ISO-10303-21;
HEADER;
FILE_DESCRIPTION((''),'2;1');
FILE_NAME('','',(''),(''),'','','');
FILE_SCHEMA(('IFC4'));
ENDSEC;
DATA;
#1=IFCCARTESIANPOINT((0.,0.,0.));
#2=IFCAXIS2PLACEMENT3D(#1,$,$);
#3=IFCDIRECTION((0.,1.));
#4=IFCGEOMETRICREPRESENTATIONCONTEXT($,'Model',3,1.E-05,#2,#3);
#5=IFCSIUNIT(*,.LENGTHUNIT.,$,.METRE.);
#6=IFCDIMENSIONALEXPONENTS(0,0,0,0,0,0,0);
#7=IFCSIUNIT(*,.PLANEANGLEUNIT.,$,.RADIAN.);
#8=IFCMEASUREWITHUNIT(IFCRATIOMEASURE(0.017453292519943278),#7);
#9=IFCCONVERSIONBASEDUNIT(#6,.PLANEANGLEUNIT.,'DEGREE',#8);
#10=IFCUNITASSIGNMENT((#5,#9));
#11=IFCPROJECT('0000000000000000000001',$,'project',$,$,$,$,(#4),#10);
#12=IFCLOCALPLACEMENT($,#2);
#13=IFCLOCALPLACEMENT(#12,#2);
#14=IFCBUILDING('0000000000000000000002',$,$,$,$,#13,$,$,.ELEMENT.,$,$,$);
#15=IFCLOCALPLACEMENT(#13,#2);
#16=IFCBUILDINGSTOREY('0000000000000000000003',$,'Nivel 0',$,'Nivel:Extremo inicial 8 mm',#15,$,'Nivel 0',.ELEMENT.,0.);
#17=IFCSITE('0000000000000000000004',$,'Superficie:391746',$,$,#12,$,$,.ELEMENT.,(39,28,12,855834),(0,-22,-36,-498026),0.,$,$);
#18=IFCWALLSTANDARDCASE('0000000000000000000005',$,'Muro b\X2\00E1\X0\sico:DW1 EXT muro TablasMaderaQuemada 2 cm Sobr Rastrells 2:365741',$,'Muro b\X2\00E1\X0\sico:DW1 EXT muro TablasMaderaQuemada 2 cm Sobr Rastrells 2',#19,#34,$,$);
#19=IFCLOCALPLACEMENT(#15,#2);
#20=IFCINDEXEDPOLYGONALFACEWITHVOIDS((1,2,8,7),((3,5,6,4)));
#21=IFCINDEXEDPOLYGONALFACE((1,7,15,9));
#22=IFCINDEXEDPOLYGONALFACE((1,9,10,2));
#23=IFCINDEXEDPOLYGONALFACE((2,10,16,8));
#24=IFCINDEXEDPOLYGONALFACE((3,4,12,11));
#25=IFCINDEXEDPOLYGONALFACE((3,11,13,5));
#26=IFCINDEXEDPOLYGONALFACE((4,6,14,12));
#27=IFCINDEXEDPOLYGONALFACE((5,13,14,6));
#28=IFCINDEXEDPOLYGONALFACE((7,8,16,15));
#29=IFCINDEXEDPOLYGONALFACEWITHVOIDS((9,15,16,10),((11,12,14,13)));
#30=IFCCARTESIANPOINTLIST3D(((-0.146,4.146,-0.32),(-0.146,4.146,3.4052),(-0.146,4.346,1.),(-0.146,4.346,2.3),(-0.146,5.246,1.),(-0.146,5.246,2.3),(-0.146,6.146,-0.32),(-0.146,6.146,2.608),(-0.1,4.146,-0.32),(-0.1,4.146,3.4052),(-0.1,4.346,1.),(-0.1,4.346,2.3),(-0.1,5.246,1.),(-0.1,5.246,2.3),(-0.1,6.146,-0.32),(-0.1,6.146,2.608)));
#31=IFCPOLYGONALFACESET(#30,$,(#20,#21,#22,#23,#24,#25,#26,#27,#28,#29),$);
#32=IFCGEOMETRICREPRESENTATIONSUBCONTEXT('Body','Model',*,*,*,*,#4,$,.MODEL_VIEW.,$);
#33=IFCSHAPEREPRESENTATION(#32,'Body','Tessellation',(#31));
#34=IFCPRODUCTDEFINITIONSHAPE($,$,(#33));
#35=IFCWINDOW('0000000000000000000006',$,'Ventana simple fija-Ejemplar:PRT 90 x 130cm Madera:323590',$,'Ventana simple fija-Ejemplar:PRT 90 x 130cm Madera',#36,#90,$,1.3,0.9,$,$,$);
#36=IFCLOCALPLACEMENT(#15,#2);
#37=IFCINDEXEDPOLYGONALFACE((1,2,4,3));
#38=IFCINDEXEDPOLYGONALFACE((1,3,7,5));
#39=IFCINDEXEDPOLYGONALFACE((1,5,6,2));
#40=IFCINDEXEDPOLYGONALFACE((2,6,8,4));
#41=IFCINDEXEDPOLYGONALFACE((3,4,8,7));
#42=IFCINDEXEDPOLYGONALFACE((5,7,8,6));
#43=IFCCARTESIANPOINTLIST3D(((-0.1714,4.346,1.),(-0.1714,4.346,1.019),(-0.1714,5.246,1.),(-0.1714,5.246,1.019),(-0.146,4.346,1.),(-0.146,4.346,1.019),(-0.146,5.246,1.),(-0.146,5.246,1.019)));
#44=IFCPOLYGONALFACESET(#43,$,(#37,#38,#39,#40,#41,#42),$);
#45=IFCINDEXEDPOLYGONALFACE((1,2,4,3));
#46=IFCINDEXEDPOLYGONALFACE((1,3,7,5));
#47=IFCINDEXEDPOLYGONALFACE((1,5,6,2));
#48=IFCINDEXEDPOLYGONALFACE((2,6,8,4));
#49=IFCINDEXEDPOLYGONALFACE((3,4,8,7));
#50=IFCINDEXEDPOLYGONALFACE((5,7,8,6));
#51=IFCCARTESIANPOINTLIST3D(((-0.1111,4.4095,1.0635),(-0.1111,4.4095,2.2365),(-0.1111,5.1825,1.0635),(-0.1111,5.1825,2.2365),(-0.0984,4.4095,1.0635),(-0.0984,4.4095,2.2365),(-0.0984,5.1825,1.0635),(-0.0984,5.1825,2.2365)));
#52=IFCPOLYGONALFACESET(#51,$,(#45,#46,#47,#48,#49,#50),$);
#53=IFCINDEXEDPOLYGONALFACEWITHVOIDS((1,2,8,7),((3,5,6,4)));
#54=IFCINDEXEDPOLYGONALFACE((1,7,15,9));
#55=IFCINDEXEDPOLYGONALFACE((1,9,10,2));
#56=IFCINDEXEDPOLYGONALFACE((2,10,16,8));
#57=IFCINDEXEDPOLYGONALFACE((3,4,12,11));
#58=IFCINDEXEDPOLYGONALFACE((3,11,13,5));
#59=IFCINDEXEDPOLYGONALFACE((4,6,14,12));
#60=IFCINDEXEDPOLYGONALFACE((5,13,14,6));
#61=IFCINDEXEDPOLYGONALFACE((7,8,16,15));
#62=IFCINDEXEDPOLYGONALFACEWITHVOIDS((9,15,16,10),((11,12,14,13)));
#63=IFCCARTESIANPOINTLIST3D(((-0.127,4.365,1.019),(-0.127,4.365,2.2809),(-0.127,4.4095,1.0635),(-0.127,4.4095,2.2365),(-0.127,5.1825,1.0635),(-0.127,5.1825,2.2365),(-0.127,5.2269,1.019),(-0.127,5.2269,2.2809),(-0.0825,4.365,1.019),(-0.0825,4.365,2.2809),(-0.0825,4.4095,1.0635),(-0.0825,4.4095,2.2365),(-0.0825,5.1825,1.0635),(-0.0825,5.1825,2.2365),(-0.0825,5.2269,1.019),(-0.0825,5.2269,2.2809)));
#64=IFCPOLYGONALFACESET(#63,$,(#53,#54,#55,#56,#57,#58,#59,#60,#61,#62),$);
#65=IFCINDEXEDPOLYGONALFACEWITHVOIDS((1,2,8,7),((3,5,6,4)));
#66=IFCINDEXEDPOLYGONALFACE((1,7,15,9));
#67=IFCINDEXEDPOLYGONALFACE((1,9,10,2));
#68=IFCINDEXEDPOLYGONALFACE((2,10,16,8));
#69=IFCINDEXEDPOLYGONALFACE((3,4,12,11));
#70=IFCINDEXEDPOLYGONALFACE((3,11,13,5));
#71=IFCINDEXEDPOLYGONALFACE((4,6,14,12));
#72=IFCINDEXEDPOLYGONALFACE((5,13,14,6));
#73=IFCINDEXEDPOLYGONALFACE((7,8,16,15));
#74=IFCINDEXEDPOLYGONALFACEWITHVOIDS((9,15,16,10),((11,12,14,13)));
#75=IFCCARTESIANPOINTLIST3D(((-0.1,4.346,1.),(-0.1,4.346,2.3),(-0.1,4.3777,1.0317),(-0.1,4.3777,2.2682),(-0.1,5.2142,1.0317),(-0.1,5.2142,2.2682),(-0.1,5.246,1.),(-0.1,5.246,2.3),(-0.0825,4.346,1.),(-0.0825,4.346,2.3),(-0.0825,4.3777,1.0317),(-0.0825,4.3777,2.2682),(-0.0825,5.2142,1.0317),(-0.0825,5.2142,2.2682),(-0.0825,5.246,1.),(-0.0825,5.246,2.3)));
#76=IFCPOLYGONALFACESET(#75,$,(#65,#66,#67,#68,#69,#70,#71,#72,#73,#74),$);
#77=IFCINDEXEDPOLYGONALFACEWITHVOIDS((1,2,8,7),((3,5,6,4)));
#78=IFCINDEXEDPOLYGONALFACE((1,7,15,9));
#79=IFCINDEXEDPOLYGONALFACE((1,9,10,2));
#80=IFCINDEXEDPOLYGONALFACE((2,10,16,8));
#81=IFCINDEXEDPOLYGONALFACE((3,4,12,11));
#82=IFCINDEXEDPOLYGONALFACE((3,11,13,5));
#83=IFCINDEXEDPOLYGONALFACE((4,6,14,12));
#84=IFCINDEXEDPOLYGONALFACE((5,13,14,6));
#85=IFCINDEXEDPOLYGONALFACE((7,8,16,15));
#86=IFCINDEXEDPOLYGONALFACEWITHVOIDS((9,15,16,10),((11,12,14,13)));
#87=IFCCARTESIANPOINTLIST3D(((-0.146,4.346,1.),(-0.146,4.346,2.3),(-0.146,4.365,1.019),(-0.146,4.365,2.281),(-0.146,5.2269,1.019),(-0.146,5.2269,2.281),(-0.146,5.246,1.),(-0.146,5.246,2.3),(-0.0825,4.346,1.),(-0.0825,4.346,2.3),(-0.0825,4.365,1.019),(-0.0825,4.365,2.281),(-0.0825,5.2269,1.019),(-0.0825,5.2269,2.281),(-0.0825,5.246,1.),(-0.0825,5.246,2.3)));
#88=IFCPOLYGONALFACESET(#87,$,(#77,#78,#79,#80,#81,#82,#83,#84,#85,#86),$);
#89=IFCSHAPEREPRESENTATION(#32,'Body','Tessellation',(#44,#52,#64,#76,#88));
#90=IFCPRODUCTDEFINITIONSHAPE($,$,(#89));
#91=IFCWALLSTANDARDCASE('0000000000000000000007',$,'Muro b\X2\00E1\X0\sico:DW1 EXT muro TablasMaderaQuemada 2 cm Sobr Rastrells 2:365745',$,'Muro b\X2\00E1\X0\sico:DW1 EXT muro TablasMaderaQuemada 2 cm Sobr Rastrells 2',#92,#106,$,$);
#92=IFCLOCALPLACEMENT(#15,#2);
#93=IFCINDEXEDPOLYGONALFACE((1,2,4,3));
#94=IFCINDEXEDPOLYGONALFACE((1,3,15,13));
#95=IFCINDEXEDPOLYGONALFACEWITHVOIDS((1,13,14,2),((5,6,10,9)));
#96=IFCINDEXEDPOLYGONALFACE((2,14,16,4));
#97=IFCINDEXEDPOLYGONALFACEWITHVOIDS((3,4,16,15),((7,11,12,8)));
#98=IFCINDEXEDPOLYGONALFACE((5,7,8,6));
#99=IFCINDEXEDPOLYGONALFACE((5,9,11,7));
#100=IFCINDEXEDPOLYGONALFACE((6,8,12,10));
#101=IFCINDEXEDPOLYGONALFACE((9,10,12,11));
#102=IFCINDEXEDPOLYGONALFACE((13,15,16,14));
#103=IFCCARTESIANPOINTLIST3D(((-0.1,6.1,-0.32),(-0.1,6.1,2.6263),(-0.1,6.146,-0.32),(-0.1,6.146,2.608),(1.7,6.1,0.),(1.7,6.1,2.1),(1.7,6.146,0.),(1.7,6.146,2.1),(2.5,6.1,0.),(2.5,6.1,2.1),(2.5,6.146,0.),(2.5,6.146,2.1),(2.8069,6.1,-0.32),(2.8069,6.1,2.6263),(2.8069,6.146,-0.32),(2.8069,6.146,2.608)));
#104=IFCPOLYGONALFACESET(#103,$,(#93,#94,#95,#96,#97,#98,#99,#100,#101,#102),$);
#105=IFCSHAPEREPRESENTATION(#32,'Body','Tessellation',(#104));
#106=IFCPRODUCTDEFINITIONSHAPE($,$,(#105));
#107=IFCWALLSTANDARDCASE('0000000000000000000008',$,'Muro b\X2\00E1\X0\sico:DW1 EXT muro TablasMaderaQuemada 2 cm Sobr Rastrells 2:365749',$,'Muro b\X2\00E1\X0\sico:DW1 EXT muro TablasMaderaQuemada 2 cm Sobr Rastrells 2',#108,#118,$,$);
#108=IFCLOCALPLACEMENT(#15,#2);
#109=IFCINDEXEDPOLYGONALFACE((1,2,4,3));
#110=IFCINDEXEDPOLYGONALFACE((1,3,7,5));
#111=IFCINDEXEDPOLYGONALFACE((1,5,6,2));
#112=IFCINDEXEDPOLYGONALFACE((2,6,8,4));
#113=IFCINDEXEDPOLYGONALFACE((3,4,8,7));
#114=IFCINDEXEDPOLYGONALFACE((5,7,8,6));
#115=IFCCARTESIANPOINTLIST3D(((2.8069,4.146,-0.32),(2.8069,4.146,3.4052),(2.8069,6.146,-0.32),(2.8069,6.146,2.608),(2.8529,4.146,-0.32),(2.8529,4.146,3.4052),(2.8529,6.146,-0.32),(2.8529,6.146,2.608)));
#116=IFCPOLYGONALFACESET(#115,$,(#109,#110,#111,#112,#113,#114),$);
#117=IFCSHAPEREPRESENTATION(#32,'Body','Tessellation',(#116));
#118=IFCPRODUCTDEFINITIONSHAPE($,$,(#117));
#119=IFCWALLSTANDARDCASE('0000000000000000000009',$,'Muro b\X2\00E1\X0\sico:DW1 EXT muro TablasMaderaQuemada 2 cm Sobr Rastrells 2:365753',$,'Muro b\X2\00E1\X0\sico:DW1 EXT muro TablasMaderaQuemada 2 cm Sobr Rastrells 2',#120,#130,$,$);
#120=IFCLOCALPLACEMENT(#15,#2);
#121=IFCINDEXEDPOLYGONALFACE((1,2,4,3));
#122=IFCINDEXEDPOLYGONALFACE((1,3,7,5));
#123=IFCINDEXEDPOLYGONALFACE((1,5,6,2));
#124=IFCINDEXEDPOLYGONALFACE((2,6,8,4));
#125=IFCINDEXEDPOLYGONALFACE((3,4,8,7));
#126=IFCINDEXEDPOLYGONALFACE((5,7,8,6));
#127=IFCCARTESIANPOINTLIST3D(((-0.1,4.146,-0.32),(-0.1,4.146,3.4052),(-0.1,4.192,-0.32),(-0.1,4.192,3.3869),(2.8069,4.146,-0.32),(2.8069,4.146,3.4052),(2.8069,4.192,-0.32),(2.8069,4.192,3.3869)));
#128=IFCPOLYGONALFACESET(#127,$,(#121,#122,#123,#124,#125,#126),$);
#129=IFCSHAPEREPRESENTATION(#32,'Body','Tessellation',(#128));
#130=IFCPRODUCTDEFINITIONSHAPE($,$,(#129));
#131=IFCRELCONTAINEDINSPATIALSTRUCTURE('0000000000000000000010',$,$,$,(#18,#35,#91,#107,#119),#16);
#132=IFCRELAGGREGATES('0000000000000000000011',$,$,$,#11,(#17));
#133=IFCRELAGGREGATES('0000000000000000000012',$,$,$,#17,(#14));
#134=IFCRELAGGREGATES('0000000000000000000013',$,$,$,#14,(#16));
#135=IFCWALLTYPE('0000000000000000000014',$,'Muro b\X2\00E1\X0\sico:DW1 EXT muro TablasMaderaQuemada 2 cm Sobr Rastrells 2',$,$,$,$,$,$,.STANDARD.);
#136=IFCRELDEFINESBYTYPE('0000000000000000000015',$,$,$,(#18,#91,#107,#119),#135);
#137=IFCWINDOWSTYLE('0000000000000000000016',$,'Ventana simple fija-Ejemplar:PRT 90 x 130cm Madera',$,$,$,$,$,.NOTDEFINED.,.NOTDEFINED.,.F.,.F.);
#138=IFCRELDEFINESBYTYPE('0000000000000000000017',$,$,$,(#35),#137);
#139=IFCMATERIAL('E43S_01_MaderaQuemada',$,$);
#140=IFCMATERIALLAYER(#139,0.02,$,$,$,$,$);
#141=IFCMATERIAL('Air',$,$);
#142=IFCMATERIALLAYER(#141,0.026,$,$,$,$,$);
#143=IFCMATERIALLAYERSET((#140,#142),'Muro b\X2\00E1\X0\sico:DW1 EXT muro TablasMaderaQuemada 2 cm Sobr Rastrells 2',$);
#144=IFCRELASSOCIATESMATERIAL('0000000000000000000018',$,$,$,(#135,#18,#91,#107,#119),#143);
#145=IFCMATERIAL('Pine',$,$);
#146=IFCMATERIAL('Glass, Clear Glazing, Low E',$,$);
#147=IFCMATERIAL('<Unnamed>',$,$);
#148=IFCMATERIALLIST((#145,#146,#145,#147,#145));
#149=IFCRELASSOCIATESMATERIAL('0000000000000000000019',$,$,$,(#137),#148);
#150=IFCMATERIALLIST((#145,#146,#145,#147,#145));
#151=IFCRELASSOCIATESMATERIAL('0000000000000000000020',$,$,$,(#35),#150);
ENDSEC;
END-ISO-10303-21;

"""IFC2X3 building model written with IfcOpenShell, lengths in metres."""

from ifc_helpers import new_model, entity, si_unit, converted_unit, direction, frame, frame_2d, origin, origin_2d_with_axis, place, context, subcontext, project, spatial, polyline, rectangle, outline, extrude, clip, bounded_halfspace, source, transform, mapped, material, material_list, layer, layer_set, layer_usage, type_object, type_shapes, element, fill, save


model = new_model("IFC2X3")

# Units and contexts
model_context = context("Model", 3, precision=1e-05, world=origin(), true_north=direction((0.0, 1.0)))
body_context = subcontext(model_context, "Body", "Model", "MODEL_VIEW")
ifc_project = project(units=[si_unit("LENGTHUNIT", "METRE"), converted_unit("PLANEANGLEUNIT", "DEGREE", entity("IfcRatioMeasure", 0.017453292519943278), si_unit("PLANEANGLEUNIT", "RADIAN"), dimensions=[0, 0, 0, 0, 0, 0, 0])], contexts=[model_context])

# Site, building, storey
site_placement = place(None, origin())
site = spatial("IfcSite", under=ifc_project, at=site_placement, Name="Superficie:391746", CompositionType="ELEMENT", RefLatitude=(39, 28, 12, 855834), RefLongitude=(0, -22, -36, -498026), RefElevation=0.0)
building_placement = place(site_placement, origin())
building = spatial("IfcBuilding", under=site, at=building_placement, CompositionType="ELEMENT")
storey_placement = place(building_placement, origin())
storey = spatial("IfcBuildingStorey", under=building, at=storey_placement, Name="Nivel 0", ObjectType="Nivel:Extremo inicial 8 mm", LongName="Nivel 0", CompositionType="ELEMENT", Elevation=0.0)

# Shared definitions
ifc_material_1 = material(Name="Pine")
ifc_material_2 = material(Name="Glass, Clear Glazing, Low E")
ifc_material_3 = material(Name="<Unnamed>")

# Wall, opening, window
ifc_material_4 = material(Name="E43S_01_MaderaQuemada")
ifc_layer_1 = layer(ifc_material_4, 0.02)
ifc_material_5 = material(Name="Air")
ifc_layer_2 = layer(ifc_material_5, 0.026)
ifc_layer_set_1 = layer_set([ifc_layer_1, ifc_layer_2], Name="Muro básico:DW1 EXT muro TablasMaderaQuemada 2 cm Sobr Rastrells 2")
ifc_layer_usage_1 = layer_usage(ifc_layer_set_1, "AXIS2", "NEGATIVE", 0.023)
wall_type_1 = type_object("IfcWallType", Name="Muro básico:DW1 EXT muro TablasMaderaQuemada 2 cm Sobr Rastrells 2", PredefinedType="STANDARD", material=ifc_layer_set_1)
wall_1_placement = place(storey_placement, frame((-0.123, 4.146, -0.32), z_axis=(0.0, 0.0, 1.0), x_axis=(0.0, 1.0, 0.0)))
wall_1 = element("IfcWallStandardCase", 1, at=wall_1_placement, inside=storey, type_object=wall_type_1, material=ifc_layer_usage_1, Name="Muro básico:DW1 EXT muro TablasMaderaQuemada 2 cm Sobr Rastrells 2:365741", ObjectType="Muro básico:DW1 EXT muro TablasMaderaQuemada 2 cm Sobr Rastrells 2", context=body_context, shape_type="Clipping", body=[
    clip(extrude(rectangle(XDim=2.0, YDim=0.046, at=frame_2d((1.0, 0.0), x_axis=(1.0, 0.0))), origin(), (0.0, 0.0, 1.0), 3.7252), bounded_halfspace(frame((0.0, -0.023, 3.7252), z_axis=(0.370288, 0.0, 0.928917), x_axis=(0.0, 1.0, 0.0)), False, frame((0.0, -0.023, 3.7252)), polyline([(0.0, 0.0), (0.046, 0.0), (1.954, 0.0), (2.0, 0.0), (2.0, 0.046), (0.0, 0.046), (0.0, 0.0)]))),
])
opening_1_placement = place(wall_1_placement, frame((0.2, -0.023, 1.32)))
opening_1 = element("IfcOpeningElement", 2, at=opening_1_placement, cuts=wall_1, ObjectType="Opening", context=body_context, shape_type="SweptSolid", body=[
    extrude(rectangle(XDim=1.3, YDim=0.9, at=frame_2d((0.65, 0.45), x_axis=(-1.0, 0.0))), frame((0.0, 0.0, 0.0), z_axis=(0.0, 1.0, 0.0), x_axis=(0.0, 0.0, 1.0)), (0.0, 0.0, 1.0), 0.046),
])
ifc_material_list_1 = material_list([ifc_material_1, ifc_material_2, ifc_material_1, ifc_material_3, ifc_material_1])
ifc_material_list_2 = material_list([ifc_material_1, ifc_material_2, ifc_material_1, ifc_material_3, ifc_material_1])
window_style_1 = type_object("IfcWindowStyle", Name="Ventana simple fija-Ejemplar:PRT 90 x 130cm Madera", ConstructionType="NOTDEFINED", OperationType="NOTDEFINED", ParameterTakesPrecedence=False, Sizeable=False, material=ifc_material_list_2)
shared_shape_1 = source(origin(), body_context, "Body", "SweptSolid", [
    extrude(rectangle(XDim=0.9, YDim=0.0254, at=origin_2d_with_axis()), frame((0.5262, 0.0587, 0.0), z_axis=(0.0, 0.0, 1.0), x_axis=(-1.0, 0.0, 0.0)), (0.0, 0.0, 1.0), 0.019),
    extrude(rectangle(XDim=0.773, YDim=0.0127, at=origin_2d_with_axis()), frame((0.5262, 0.0048, 0.0635)), (0.0, 0.0, 1.0), 1.173),
    extrude(outline(polyline([(-0.431, -0.631), (0.431, -0.631), (0.431, 0.631), (-0.431, 0.631), (-0.431, -0.631)]), holes=[polyline([(-0.3865, -0.5865), (-0.3865, 0.5865), (0.3865, 0.5865), (0.3865, -0.5865), (-0.3865, -0.5865)])]), frame((0.5262, 0.027, 0.65), z_axis=(0.0, -1.0, 0.0), x_axis=(-1.0, 0.0, 0.0)), (0.0, 0.0, 1.0), 0.0444),
    extrude(outline(polyline([(-0.45, -0.65), (0.45, -0.65), (0.45, 0.65), (-0.45, 0.65), (-0.45, -0.65)]), holes=[polyline([(-0.4183, -0.6182), (-0.4183, 0.6183), (0.4183, 0.6183), (0.4183, -0.6182), (-0.4183, -0.6182)])]), frame((0.5262, 0.0, 0.65), z_axis=(0.0, -1.0, 0.0), x_axis=(-1.0, 0.0, 0.0)), (0.0, 0.0, 1.0), 0.0175),
    extrude(outline(polyline([(-0.65, -0.45), (0.65, -0.45), (0.65, 0.45), (-0.65, 0.45), (-0.65, -0.45)]), holes=[polyline([(-0.6309, -0.431), (-0.6309, 0.431), (0.631, 0.431), (0.631, -0.431), (-0.6309, -0.431)])]), frame((0.5262, 0.046, 0.65), z_axis=(0.0, -1.0, 0.0), x_axis=(0.0, 0.0, -1.0)), (0.0, 0.0, 1.0), 0.0635),
])
type_shapes(window_style_1, [shared_shape_1])
window_1_placement = place(opening_1_placement, frame((-0.0762, 0.0, 0.0)))
window_1 = element("IfcWindow", 3, at=window_1_placement, inside=storey, type_object=window_style_1, material=ifc_material_list_1, Name="Ventana simple fija-Ejemplar:PRT 90 x 130cm Madera:323590", ObjectType="Ventana simple fija-Ejemplar:PRT 90 x 130cm Madera", OverallHeight=1.3, OverallWidth=0.9, context=body_context, shape_type="MappedRepresentation", body=[
    mapped(shared_shape_1, transform((0.0, 0.0, 0.0), scale=1.0)),
])
fill(opening_1, window_1)

# Wall, opening
ifc_layer_usage_2 = layer_usage(ifc_layer_set_1, "AXIS2", "NEGATIVE", 0.023)
wall_2_placement = place(storey_placement, frame((-0.1, 6.123, -0.32)))
wall_2 = element("IfcWallStandardCase", 4, at=wall_2_placement, inside=storey, type_object=wall_type_1, material=ifc_layer_usage_2, Name="Muro básico:DW1 EXT muro TablasMaderaQuemada 2 cm Sobr Rastrells 2:365745", ObjectType="Muro básico:DW1 EXT muro TablasMaderaQuemada 2 cm Sobr Rastrells 2", context=body_context, shape_type="Clipping", body=[
    clip(extrude(rectangle(XDim=2.9069, YDim=0.046, at=frame_2d((1.4535, 0.0), x_axis=(-1.0, 0.0))), origin(), (0.0, 0.0, 1.0), 2.9463), bounded_halfspace(frame((0.0, -0.023, 2.9463), z_axis=(0.0, 0.370288, 0.928917), x_axis=(-1.0, 0.0, 0.0)), False, frame((0.0, -0.023, 2.9463), z_axis=(0.0, 0.370288, 0.928917), x_axis=(-1.0, 0.0, 0.0)), polyline([(0.0, 0.0), (-0.2, 0.0), (-2.7069, 0.0), (-2.9069, 0.0), (-2.9069, -0.0495), (0.0, -0.0495), (0.0, 0.0)]))),
])
opening_2_placement = place(wall_2_placement, frame((1.8, -1.547, 0.32)))
element("IfcOpeningElement", 5, at=opening_2_placement, cuts=wall_2, ObjectType="Opening", context=body_context, shape_type="SweptSolid", body=[
    extrude(rectangle(XDim=2.1, YDim=0.8, at=frame_2d((0.0, 0.0), x_axis=(1.0, 0.0))), frame((0.4, 0.0, 1.05), z_axis=(0.0, 1.0, 0.0), x_axis=(0.0, 0.0, -1.0)), (0.0, 0.0, 1.0), 3.048),
])

# Walls
ifc_layer_usage_3 = layer_usage(ifc_layer_set_1, "AXIS2", "NEGATIVE", 0.023)
wall_3_placement = place(storey_placement, frame((2.8299, 6.146, -0.32), z_axis=(0.0, 0.0, 1.0), x_axis=(0.0, -1.0, 0.0)))
element("IfcWallStandardCase", 6, at=wall_3_placement, inside=storey, type_object=wall_type_1, material=ifc_layer_usage_3, Name="Muro básico:DW1 EXT muro TablasMaderaQuemada 2 cm Sobr Rastrells 2:365749", ObjectType="Muro básico:DW1 EXT muro TablasMaderaQuemada 2 cm Sobr Rastrells 2", context=body_context, shape_type="Clipping", body=[
    clip(extrude(rectangle(XDim=2.0, YDim=0.046, at=frame_2d((1.0, 0.0), x_axis=(-1.0, 0.0))), origin(), (0.0, 0.0, 1.0), 3.7252), bounded_halfspace(frame((0.0, 0.023, 2.928), z_axis=(-0.370288, 0.0, 0.928917), x_axis=(0.0, -1.0, 0.0)), False, frame((0.0, 0.023, 2.928)), polyline([(0.0, 0.0), (0.0, -0.046), (0.046, -0.046), (1.954, -0.046), (2.0, -0.046), (2.0, 0.0), (0.0, 0.0)]))),
])
ifc_layer_usage_4 = layer_usage(ifc_layer_set_1, "AXIS2", "NEGATIVE", 0.023)
wall_4_placement = place(storey_placement, frame((2.8069, 4.169, -0.32), z_axis=(0.0, 0.0, 1.0), x_axis=(-1.0, 0.0, 0.0)))
element("IfcWallStandardCase", 7, at=wall_4_placement, inside=storey, type_object=wall_type_1, material=ifc_layer_usage_4, Name="Muro básico:DW1 EXT muro TablasMaderaQuemada 2 cm Sobr Rastrells 2:365753", ObjectType="Muro básico:DW1 EXT muro TablasMaderaQuemada 2 cm Sobr Rastrells 2", context=body_context, shape_type="Clipping", body=[
    clip(extrude(rectangle(XDim=2.9069, YDim=0.046, at=frame_2d((1.4535, 0.0), x_axis=(-1.0, 0.0))), origin(), (0.0, 0.0, 1.0), 3.7252), bounded_halfspace(frame((0.0, -0.023, 3.7069), z_axis=(0.0, -0.370288, 0.928917), x_axis=(1.0, 0.0, 0.0)), False, frame((0.0, -0.023, 3.7069), z_axis=(0.0, -0.370288, 0.928917), x_axis=(1.0, 0.0, 0.0)), polyline([(0.0, 0.0), (2.9069, 0.0), (2.9069, 0.0495), (0.0, 0.0495), (0.0, 0.0)]))),
])

save(model, "model.ifc")
